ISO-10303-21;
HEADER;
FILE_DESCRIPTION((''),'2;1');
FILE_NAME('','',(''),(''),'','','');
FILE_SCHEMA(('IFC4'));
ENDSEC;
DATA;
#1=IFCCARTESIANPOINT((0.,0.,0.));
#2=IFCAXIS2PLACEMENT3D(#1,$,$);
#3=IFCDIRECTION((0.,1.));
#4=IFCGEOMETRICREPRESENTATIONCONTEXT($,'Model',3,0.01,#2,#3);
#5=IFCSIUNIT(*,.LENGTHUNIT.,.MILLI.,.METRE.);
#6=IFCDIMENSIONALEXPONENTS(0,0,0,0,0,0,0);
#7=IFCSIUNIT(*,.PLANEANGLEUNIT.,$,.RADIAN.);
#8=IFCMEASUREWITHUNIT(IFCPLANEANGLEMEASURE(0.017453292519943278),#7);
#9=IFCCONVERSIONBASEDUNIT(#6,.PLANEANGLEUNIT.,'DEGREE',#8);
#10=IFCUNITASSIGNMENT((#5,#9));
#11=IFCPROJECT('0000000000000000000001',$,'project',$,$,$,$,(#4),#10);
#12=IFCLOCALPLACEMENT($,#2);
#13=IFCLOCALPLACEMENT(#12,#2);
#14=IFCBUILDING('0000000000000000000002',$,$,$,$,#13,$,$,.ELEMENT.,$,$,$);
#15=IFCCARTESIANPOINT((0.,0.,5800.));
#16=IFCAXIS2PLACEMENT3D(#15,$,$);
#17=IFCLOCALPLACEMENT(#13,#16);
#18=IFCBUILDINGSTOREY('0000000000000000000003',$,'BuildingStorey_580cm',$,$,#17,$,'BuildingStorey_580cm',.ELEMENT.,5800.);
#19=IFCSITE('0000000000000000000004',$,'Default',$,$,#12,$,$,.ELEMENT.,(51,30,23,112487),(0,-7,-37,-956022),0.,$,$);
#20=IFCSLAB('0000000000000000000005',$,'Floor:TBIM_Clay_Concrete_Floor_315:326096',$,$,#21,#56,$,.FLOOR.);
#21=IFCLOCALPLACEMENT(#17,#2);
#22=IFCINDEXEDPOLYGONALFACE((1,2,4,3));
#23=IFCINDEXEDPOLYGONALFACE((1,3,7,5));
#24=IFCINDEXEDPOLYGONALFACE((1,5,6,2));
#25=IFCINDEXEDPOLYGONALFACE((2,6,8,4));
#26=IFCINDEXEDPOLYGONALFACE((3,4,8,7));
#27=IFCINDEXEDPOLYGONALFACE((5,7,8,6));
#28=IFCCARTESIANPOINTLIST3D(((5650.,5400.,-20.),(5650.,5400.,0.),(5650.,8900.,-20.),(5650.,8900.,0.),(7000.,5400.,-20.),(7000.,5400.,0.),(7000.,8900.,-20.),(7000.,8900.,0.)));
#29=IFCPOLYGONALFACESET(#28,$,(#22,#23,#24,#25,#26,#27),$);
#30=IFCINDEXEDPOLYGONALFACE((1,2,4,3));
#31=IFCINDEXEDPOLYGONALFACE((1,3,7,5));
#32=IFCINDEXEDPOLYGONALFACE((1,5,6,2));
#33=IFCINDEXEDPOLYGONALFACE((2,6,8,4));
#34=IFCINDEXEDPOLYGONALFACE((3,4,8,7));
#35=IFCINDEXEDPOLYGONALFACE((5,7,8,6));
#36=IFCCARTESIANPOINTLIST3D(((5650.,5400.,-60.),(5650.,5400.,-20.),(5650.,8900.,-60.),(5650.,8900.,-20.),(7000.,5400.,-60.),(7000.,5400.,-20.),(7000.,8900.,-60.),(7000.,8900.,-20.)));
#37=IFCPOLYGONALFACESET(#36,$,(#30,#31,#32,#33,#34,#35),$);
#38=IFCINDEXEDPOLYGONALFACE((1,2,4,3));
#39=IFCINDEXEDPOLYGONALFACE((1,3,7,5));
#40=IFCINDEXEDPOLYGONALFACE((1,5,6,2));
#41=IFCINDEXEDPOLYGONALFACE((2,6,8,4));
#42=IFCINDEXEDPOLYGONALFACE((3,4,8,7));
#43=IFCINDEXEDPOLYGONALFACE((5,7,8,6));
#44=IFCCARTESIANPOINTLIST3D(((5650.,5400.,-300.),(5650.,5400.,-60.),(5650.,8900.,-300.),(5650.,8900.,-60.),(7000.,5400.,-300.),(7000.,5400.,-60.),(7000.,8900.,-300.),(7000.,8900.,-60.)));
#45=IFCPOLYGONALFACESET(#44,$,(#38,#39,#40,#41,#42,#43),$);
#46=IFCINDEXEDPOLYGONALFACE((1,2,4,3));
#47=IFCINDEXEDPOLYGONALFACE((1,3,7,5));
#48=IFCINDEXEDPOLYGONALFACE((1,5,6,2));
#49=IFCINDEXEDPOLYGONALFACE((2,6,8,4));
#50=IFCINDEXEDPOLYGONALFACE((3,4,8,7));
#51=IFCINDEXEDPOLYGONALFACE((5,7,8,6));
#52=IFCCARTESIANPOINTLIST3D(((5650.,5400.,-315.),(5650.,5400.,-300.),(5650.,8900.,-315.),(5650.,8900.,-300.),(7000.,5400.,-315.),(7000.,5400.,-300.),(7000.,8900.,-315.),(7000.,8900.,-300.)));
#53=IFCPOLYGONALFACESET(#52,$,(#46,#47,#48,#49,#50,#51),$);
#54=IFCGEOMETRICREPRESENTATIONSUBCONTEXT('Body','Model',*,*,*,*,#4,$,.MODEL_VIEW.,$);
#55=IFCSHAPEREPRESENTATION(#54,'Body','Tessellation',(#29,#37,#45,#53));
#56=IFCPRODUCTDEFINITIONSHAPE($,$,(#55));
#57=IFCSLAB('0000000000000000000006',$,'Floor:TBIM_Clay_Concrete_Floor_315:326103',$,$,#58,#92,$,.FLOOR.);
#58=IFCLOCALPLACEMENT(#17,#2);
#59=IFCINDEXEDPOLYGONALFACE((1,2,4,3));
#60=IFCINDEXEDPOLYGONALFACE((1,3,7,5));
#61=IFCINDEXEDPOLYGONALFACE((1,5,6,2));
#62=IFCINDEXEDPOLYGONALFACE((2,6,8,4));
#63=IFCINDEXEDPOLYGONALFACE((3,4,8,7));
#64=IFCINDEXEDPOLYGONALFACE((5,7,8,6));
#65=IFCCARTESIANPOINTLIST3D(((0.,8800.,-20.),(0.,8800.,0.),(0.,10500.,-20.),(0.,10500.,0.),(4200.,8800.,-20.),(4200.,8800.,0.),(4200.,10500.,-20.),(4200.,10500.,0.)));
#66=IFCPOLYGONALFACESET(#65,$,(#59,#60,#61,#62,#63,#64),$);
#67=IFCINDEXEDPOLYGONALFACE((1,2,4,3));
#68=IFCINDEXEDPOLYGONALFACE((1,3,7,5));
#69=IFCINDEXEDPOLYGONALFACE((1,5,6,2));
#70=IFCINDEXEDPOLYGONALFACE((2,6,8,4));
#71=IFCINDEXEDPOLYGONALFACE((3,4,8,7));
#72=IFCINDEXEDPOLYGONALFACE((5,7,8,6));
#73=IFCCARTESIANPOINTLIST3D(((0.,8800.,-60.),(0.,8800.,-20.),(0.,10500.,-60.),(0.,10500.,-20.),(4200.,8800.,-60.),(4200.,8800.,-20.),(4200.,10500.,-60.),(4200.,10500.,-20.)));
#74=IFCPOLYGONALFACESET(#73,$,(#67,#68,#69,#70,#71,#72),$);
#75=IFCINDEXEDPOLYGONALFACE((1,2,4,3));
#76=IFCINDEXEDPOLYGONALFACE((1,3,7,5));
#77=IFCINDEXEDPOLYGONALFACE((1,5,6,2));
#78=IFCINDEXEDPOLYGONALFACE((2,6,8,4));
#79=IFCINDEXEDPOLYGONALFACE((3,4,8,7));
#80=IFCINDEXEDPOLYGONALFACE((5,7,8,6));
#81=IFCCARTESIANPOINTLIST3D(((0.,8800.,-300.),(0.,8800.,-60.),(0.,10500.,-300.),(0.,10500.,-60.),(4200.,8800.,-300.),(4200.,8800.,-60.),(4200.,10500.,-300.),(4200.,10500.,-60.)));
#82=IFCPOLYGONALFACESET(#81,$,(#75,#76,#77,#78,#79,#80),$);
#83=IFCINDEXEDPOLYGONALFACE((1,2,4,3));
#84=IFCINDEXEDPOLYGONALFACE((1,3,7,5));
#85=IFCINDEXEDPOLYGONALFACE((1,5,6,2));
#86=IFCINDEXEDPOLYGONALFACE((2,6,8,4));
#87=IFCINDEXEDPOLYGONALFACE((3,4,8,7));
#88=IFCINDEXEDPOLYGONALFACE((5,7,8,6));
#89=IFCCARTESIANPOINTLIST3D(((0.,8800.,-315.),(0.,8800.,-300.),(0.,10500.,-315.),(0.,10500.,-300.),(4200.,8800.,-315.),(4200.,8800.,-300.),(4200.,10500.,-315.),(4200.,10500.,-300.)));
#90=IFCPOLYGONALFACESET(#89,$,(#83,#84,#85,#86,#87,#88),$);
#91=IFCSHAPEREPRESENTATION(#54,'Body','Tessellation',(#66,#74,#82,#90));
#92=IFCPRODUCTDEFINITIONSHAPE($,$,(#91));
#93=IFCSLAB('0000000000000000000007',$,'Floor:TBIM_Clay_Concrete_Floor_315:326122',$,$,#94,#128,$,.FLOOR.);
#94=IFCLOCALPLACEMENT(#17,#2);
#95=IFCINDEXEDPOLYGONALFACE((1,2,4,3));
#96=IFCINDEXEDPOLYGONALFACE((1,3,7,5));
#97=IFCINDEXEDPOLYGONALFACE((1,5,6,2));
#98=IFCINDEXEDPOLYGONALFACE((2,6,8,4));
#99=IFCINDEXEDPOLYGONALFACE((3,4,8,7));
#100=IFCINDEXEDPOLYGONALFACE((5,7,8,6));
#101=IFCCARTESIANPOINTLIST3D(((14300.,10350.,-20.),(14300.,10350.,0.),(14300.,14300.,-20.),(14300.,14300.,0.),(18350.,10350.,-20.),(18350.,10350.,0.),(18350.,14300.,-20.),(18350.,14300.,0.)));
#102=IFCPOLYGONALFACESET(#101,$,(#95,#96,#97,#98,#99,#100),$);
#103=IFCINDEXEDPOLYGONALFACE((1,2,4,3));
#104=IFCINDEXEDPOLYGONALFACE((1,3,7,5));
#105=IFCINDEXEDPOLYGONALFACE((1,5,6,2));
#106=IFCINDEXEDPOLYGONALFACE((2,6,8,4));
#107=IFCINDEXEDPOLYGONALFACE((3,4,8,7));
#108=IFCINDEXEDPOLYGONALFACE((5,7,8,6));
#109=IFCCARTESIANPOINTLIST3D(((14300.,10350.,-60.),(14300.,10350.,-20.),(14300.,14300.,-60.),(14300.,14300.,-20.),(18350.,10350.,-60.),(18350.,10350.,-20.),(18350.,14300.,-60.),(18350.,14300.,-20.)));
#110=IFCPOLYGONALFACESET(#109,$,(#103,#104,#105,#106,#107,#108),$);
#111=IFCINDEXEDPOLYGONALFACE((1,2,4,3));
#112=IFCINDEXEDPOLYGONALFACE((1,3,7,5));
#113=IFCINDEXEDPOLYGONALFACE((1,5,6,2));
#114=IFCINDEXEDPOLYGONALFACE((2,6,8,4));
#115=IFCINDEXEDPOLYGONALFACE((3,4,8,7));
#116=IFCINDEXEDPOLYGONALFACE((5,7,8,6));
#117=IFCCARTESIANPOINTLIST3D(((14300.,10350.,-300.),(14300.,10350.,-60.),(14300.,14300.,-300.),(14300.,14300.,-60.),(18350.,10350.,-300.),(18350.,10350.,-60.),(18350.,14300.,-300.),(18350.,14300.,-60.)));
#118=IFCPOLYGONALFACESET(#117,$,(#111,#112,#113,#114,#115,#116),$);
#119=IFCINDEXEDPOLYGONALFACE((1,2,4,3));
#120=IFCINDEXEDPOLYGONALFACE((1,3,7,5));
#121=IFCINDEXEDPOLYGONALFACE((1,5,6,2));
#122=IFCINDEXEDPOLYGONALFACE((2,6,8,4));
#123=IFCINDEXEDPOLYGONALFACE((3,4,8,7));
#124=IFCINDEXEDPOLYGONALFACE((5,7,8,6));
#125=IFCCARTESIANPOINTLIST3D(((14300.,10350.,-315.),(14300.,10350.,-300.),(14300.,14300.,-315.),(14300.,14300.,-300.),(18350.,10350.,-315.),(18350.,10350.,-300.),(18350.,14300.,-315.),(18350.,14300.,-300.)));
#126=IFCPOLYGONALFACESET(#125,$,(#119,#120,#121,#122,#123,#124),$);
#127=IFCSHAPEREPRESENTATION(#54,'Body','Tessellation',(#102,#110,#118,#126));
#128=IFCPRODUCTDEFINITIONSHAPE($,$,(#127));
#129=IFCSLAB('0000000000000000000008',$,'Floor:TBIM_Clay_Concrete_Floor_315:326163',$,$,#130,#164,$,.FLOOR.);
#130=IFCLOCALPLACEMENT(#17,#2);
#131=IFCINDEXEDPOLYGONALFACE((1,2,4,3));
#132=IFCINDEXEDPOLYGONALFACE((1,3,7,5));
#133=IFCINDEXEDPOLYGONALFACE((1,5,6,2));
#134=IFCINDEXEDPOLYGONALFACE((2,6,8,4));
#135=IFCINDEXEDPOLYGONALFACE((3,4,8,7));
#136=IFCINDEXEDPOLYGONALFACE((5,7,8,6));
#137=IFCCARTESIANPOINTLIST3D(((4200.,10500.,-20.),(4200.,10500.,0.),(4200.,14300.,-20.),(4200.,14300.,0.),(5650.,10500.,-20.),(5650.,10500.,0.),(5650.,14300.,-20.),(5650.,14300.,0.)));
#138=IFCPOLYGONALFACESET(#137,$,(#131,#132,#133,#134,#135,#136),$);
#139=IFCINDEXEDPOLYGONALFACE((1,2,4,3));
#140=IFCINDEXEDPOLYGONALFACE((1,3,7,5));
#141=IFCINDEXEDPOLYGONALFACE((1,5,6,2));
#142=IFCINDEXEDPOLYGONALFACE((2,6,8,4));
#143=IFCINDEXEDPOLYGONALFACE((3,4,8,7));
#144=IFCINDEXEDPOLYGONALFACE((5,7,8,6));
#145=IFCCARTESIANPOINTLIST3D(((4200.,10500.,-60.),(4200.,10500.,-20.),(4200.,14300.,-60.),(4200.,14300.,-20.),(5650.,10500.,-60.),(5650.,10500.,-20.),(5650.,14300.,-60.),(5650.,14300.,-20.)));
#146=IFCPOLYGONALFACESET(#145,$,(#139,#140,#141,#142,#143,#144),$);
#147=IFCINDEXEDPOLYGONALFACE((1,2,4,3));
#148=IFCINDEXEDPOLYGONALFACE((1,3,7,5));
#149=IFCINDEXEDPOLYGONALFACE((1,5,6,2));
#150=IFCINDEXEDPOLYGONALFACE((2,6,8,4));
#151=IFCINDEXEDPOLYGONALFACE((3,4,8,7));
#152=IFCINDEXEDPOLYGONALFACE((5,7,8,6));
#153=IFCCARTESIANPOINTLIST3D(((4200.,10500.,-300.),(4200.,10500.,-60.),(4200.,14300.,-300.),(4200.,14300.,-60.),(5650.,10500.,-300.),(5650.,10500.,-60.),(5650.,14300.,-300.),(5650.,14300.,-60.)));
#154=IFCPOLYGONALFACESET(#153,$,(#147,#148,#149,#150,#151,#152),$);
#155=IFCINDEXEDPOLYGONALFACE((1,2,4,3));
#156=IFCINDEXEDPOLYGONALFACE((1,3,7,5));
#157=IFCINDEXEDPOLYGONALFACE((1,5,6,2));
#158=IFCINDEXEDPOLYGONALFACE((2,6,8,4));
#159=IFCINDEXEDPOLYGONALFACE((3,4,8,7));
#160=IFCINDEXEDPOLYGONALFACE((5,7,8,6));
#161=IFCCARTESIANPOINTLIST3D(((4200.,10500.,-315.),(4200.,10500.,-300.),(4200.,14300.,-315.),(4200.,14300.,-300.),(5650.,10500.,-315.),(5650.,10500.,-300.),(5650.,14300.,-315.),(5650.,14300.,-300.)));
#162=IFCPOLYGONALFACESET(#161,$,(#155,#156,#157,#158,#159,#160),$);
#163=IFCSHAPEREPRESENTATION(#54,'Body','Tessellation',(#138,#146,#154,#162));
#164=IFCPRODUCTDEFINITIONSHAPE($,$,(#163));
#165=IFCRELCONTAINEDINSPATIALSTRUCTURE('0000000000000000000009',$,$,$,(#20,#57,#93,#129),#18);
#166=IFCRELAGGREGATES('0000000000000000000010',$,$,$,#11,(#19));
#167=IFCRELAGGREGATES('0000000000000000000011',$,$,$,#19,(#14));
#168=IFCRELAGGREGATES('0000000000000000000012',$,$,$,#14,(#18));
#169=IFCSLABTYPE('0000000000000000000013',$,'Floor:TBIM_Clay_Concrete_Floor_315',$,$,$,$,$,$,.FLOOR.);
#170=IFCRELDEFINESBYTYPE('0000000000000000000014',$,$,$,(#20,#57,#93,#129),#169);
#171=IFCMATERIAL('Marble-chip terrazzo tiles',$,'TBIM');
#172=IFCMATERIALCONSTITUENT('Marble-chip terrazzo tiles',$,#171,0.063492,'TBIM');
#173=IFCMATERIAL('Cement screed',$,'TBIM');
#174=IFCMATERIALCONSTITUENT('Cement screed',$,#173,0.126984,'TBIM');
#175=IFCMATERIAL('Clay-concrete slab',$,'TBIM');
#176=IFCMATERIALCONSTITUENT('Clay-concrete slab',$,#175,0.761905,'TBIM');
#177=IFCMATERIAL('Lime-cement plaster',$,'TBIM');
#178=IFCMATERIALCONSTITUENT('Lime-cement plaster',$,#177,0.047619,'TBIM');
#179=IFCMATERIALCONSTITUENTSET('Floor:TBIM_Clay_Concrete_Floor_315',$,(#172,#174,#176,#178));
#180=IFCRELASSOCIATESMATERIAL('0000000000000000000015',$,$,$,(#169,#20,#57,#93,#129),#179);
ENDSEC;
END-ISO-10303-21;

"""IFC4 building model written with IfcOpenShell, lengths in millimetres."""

from ifc_helpers import new_model, entity, si_unit, converted_unit, direction, frame, origin, place, context, subcontext, project, spatial, indexed_curve, outline, extrude, material, constituent, constituent_set, type_object, element, save


model = new_model("IFC4")

# Units and contexts
model_context = context("Model", 3, precision=0.01, world=origin(), true_north=direction((0.0, 1.0)))
body_context = subcontext(model_context, "Body", "Model", "MODEL_VIEW")
ifc_project = project(units=[si_unit("LENGTHUNIT", "METRE", prefix="MILLI"), converted_unit("PLANEANGLEUNIT", "DEGREE", entity("IfcPlaneAngleMeasure", 0.017453292519943278), si_unit("PLANEANGLEUNIT", "RADIAN"), dimensions=[0, 0, 0, 0, 0, 0, 0])], contexts=[model_context])

# Site, building, storey
site_placement = place(None, origin())
site = spatial("IfcSite", under=ifc_project, at=site_placement, Name="Default", CompositionType="ELEMENT", RefLatitude=(51, 30, 23, 112487), RefLongitude=(0, -7, -37, -956022), RefElevation=0.0)
building_placement = place(site_placement, origin())
building = spatial("IfcBuilding", under=site, at=building_placement, CompositionType="ELEMENT")
storey_placement = place(building_placement, frame((0.0, 0.0, 5800.0)))
storey = spatial("IfcBuildingStorey", under=building, at=storey_placement, Name="BuildingStorey_580cm", LongName="BuildingStorey_580cm", CompositionType="ELEMENT", Elevation=5800.0)

# Slabs
ifc_material_1 = material(Name="Marble-chip terrazzo tiles", Category="TBIM")
ifc_constituent_1 = constituent(ifc_material_1, Name="Marble-chip terrazzo tiles", Category="TBIM", fraction=0.063492)
ifc_material_2 = material(Name="Cement screed", Category="TBIM")
ifc_constituent_2 = constituent(ifc_material_2, Name="Cement screed", Category="TBIM", fraction=0.126984)
ifc_material_3 = material(Name="Clay-concrete slab", Category="TBIM")
ifc_constituent_3 = constituent(ifc_material_3, Name="Clay-concrete slab", Category="TBIM", fraction=0.761905)
ifc_material_4 = material(Name="Lime-cement plaster", Category="TBIM")
ifc_constituent_4 = constituent(ifc_material_4, Name="Lime-cement plaster", Category="TBIM", fraction=0.047619)
ifc_constituent_set_1 = constituent_set(constituents=[ifc_constituent_1, ifc_constituent_2, ifc_constituent_3, ifc_constituent_4], Name="Floor:TBIM_Clay_Concrete_Floor_315")
slab_type = type_object("IfcSlabType", Name="Floor:TBIM_Clay_Concrete_Floor_315", PredefinedType="FLOOR", material=ifc_constituent_set_1)
slab_1_placement = place(storey_placement, origin())
element("IfcSlab", 1, at=slab_1_placement, inside=storey, type_object=slab_type, material=ifc_constituent_set_1, Name="Floor:TBIM_Clay_Concrete_Floor_315:326096", PredefinedType="FLOOR", context=body_context, shape_type="SweptSolid", body=[
    extrude(outline(indexed_curve([(-675.0, -1750.0), (675.0, -1750.0), (675.0, 1750.0), (-675.0, 1750.0), (-675.0, -1750.0)], self_intersect=False)), frame((6325.0, 7150.0, -20.0), z_axis=(0.0, 0.0, 1.0), x_axis=(-1.0, 0.0, 0.0)), (0.0, 0.0, 1.0), 20.0),
    extrude(outline(indexed_curve([(-675.0, -1750.0), (675.0, -1750.0), (675.0, 1750.0), (-675.0, 1750.0), (-675.0, -1750.0)], self_intersect=False)), frame((6325.0, 7150.0, -60.0), z_axis=(0.0, 0.0, 1.0), x_axis=(-1.0, 0.0, 0.0)), (0.0, 0.0, 1.0), 40.0),
    extrude(outline(indexed_curve([(-675.0, -1750.0), (675.0, -1750.0), (675.0, 1750.0), (-675.0, 1750.0), (-675.0, -1750.0)], self_intersect=False)), frame((6325.0, 7150.0, -300.0), z_axis=(0.0, 0.0, 1.0), x_axis=(-1.0, 0.0, 0.0)), (0.0, 0.0, 1.0), 240.0),
    extrude(outline(indexed_curve([(-675.0, -1750.0), (675.0, -1750.0), (675.0, 1750.0), (-675.0, 1750.0), (-675.0, -1750.0)], self_intersect=False)), frame((6325.0, 7150.0, -315.0), z_axis=(0.0, 0.0, 1.0), x_axis=(-1.0, 0.0, 0.0)), (0.0, 0.0, 1.0), 15.0),
])
slab_2_placement = place(storey_placement, origin())
element("IfcSlab", 2, at=slab_2_placement, inside=storey, type_object=slab_type, material=ifc_constituent_set_1, Name="Floor:TBIM_Clay_Concrete_Floor_315:326103", PredefinedType="FLOOR", context=body_context, shape_type="SweptSolid", body=[
    extrude(outline(indexed_curve([(-2100.0, -850.0), (2100.0, -850.0), (2100.0, 850.0), (-2100.0, 850.0), (-2100.0, -850.0)], self_intersect=False)), frame((2100.0, 9650.0, -20.0), z_axis=(0.0, 0.0, 1.0), x_axis=(-1.0, 0.0, 0.0)), (0.0, 0.0, 1.0), 20.0),
    extrude(outline(indexed_curve([(-2100.0, -850.0), (2100.0, -850.0), (2100.0, 850.0), (-2100.0, 850.0), (-2100.0, -850.0)], self_intersect=False)), frame((2100.0, 9650.0, -60.0), z_axis=(0.0, 0.0, 1.0), x_axis=(-1.0, 0.0, 0.0)), (0.0, 0.0, 1.0), 40.0),
    extrude(outline(indexed_curve([(-2100.0, -850.0), (2100.0, -850.0), (2100.0, 850.0), (-2100.0, 850.0), (-2100.0, -850.0)], self_intersect=False)), frame((2100.0, 9650.0, -300.0), z_axis=(0.0, 0.0, 1.0), x_axis=(-1.0, 0.0, 0.0)), (0.0, 0.0, 1.0), 240.0),
    extrude(outline(indexed_curve([(-2100.0, -850.0), (2100.0, -850.0), (2100.0, 850.0), (-2100.0, 850.0), (-2100.0, -850.0)], self_intersect=False)), frame((2100.0, 9650.0, -315.0), z_axis=(0.0, 0.0, 1.0), x_axis=(-1.0, 0.0, 0.0)), (0.0, 0.0, 1.0), 15.0),
])
slab_3_placement = place(storey_placement, origin())
element("IfcSlab", 3, at=slab_3_placement, inside=storey, type_object=slab_type, material=ifc_constituent_set_1, Name="Floor:TBIM_Clay_Concrete_Floor_315:326122", PredefinedType="FLOOR", context=body_context, shape_type="SweptSolid", body=[
    extrude(outline(indexed_curve([(-2025.0, -1975.0), (2025.0, -1975.0), (2025.0, 1975.0), (-2025.0, 1975.0), (-2025.0, -1975.0)], self_intersect=False)), frame((16325.0, 12325.0, -20.0), z_axis=(0.0, 0.0, 1.0), x_axis=(-1.0, 0.0, 0.0)), (0.0, 0.0, 1.0), 20.0),
    extrude(outline(indexed_curve([(-2025.0, -1975.0), (2025.0, -1975.0), (2025.0, 1975.0), (-2025.0, 1975.0), (-2025.0, -1975.0)], self_intersect=False)), frame((16325.0, 12325.0, -60.0), z_axis=(0.0, 0.0, 1.0), x_axis=(-1.0, 0.0, 0.0)), (0.0, 0.0, 1.0), 40.0),
    extrude(outline(indexed_curve([(-2025.0, -1975.0), (2025.0, -1975.0), (2025.0, 1975.0), (-2025.0, 1975.0), (-2025.0, -1975.0)], self_intersect=False)), frame((16325.0, 12325.0, -300.0), z_axis=(0.0, 0.0, 1.0), x_axis=(-1.0, 0.0, 0.0)), (0.0, 0.0, 1.0), 240.0),
    extrude(outline(indexed_curve([(-2025.0, -1975.0), (2025.0, -1975.0), (2025.0, 1975.0), (-2025.0, 1975.0), (-2025.0, -1975.0)], self_intersect=False)), frame((16325.0, 12325.0, -315.0), z_axis=(0.0, 0.0, 1.0), x_axis=(-1.0, 0.0, 0.0)), (0.0, 0.0, 1.0), 15.0),
])
slab_4_placement = place(storey_placement, origin())
element("IfcSlab", 4, at=slab_4_placement, inside=storey, type_object=slab_type, material=ifc_constituent_set_1, Name="Floor:TBIM_Clay_Concrete_Floor_315:326163", PredefinedType="FLOOR", context=body_context, shape_type="SweptSolid", body=[
    extrude(outline(indexed_curve([(-725.0, -1900.0), (725.0, -1900.0), (725.0, 1900.0), (-725.0, 1900.0), (-725.0, -1900.0)], self_intersect=False)), frame((4925.0, 12400.0, -20.0), z_axis=(0.0, 0.0, 1.0), x_axis=(-1.0, 0.0, 0.0)), (0.0, 0.0, 1.0), 20.0),
    extrude(outline(indexed_curve([(-725.0, -1900.0), (725.0, -1900.0), (725.0, 1900.0), (-725.0, 1900.0), (-725.0, -1900.0)], self_intersect=False)), frame((4925.0, 12400.0, -60.0), z_axis=(0.0, 0.0, 1.0), x_axis=(-1.0, 0.0, 0.0)), (0.0, 0.0, 1.0), 40.0),
    extrude(outline(indexed_curve([(-725.0, -1900.0), (725.0, -1900.0), (725.0, 1900.0), (-725.0, 1900.0), (-725.0, -1900.0)], self_intersect=False)), frame((4925.0, 12400.0, -300.0), z_axis=(0.0, 0.0, 1.0), x_axis=(-1.0, 0.0, 0.0)), (0.0, 0.0, 1.0), 240.0),
    extrude(outline(indexed_curve([(-725.0, -1900.0), (725.0, -1900.0), (725.0, 1900.0), (-725.0, 1900.0), (-725.0, -1900.0)], self_intersect=False)), frame((4925.0, 12400.0, -315.0), z_axis=(0.0, 0.0, 1.0), x_axis=(-1.0, 0.0, 0.0)), (0.0, 0.0, 1.0), 15.0),
])

save(model, "model.ifc")
